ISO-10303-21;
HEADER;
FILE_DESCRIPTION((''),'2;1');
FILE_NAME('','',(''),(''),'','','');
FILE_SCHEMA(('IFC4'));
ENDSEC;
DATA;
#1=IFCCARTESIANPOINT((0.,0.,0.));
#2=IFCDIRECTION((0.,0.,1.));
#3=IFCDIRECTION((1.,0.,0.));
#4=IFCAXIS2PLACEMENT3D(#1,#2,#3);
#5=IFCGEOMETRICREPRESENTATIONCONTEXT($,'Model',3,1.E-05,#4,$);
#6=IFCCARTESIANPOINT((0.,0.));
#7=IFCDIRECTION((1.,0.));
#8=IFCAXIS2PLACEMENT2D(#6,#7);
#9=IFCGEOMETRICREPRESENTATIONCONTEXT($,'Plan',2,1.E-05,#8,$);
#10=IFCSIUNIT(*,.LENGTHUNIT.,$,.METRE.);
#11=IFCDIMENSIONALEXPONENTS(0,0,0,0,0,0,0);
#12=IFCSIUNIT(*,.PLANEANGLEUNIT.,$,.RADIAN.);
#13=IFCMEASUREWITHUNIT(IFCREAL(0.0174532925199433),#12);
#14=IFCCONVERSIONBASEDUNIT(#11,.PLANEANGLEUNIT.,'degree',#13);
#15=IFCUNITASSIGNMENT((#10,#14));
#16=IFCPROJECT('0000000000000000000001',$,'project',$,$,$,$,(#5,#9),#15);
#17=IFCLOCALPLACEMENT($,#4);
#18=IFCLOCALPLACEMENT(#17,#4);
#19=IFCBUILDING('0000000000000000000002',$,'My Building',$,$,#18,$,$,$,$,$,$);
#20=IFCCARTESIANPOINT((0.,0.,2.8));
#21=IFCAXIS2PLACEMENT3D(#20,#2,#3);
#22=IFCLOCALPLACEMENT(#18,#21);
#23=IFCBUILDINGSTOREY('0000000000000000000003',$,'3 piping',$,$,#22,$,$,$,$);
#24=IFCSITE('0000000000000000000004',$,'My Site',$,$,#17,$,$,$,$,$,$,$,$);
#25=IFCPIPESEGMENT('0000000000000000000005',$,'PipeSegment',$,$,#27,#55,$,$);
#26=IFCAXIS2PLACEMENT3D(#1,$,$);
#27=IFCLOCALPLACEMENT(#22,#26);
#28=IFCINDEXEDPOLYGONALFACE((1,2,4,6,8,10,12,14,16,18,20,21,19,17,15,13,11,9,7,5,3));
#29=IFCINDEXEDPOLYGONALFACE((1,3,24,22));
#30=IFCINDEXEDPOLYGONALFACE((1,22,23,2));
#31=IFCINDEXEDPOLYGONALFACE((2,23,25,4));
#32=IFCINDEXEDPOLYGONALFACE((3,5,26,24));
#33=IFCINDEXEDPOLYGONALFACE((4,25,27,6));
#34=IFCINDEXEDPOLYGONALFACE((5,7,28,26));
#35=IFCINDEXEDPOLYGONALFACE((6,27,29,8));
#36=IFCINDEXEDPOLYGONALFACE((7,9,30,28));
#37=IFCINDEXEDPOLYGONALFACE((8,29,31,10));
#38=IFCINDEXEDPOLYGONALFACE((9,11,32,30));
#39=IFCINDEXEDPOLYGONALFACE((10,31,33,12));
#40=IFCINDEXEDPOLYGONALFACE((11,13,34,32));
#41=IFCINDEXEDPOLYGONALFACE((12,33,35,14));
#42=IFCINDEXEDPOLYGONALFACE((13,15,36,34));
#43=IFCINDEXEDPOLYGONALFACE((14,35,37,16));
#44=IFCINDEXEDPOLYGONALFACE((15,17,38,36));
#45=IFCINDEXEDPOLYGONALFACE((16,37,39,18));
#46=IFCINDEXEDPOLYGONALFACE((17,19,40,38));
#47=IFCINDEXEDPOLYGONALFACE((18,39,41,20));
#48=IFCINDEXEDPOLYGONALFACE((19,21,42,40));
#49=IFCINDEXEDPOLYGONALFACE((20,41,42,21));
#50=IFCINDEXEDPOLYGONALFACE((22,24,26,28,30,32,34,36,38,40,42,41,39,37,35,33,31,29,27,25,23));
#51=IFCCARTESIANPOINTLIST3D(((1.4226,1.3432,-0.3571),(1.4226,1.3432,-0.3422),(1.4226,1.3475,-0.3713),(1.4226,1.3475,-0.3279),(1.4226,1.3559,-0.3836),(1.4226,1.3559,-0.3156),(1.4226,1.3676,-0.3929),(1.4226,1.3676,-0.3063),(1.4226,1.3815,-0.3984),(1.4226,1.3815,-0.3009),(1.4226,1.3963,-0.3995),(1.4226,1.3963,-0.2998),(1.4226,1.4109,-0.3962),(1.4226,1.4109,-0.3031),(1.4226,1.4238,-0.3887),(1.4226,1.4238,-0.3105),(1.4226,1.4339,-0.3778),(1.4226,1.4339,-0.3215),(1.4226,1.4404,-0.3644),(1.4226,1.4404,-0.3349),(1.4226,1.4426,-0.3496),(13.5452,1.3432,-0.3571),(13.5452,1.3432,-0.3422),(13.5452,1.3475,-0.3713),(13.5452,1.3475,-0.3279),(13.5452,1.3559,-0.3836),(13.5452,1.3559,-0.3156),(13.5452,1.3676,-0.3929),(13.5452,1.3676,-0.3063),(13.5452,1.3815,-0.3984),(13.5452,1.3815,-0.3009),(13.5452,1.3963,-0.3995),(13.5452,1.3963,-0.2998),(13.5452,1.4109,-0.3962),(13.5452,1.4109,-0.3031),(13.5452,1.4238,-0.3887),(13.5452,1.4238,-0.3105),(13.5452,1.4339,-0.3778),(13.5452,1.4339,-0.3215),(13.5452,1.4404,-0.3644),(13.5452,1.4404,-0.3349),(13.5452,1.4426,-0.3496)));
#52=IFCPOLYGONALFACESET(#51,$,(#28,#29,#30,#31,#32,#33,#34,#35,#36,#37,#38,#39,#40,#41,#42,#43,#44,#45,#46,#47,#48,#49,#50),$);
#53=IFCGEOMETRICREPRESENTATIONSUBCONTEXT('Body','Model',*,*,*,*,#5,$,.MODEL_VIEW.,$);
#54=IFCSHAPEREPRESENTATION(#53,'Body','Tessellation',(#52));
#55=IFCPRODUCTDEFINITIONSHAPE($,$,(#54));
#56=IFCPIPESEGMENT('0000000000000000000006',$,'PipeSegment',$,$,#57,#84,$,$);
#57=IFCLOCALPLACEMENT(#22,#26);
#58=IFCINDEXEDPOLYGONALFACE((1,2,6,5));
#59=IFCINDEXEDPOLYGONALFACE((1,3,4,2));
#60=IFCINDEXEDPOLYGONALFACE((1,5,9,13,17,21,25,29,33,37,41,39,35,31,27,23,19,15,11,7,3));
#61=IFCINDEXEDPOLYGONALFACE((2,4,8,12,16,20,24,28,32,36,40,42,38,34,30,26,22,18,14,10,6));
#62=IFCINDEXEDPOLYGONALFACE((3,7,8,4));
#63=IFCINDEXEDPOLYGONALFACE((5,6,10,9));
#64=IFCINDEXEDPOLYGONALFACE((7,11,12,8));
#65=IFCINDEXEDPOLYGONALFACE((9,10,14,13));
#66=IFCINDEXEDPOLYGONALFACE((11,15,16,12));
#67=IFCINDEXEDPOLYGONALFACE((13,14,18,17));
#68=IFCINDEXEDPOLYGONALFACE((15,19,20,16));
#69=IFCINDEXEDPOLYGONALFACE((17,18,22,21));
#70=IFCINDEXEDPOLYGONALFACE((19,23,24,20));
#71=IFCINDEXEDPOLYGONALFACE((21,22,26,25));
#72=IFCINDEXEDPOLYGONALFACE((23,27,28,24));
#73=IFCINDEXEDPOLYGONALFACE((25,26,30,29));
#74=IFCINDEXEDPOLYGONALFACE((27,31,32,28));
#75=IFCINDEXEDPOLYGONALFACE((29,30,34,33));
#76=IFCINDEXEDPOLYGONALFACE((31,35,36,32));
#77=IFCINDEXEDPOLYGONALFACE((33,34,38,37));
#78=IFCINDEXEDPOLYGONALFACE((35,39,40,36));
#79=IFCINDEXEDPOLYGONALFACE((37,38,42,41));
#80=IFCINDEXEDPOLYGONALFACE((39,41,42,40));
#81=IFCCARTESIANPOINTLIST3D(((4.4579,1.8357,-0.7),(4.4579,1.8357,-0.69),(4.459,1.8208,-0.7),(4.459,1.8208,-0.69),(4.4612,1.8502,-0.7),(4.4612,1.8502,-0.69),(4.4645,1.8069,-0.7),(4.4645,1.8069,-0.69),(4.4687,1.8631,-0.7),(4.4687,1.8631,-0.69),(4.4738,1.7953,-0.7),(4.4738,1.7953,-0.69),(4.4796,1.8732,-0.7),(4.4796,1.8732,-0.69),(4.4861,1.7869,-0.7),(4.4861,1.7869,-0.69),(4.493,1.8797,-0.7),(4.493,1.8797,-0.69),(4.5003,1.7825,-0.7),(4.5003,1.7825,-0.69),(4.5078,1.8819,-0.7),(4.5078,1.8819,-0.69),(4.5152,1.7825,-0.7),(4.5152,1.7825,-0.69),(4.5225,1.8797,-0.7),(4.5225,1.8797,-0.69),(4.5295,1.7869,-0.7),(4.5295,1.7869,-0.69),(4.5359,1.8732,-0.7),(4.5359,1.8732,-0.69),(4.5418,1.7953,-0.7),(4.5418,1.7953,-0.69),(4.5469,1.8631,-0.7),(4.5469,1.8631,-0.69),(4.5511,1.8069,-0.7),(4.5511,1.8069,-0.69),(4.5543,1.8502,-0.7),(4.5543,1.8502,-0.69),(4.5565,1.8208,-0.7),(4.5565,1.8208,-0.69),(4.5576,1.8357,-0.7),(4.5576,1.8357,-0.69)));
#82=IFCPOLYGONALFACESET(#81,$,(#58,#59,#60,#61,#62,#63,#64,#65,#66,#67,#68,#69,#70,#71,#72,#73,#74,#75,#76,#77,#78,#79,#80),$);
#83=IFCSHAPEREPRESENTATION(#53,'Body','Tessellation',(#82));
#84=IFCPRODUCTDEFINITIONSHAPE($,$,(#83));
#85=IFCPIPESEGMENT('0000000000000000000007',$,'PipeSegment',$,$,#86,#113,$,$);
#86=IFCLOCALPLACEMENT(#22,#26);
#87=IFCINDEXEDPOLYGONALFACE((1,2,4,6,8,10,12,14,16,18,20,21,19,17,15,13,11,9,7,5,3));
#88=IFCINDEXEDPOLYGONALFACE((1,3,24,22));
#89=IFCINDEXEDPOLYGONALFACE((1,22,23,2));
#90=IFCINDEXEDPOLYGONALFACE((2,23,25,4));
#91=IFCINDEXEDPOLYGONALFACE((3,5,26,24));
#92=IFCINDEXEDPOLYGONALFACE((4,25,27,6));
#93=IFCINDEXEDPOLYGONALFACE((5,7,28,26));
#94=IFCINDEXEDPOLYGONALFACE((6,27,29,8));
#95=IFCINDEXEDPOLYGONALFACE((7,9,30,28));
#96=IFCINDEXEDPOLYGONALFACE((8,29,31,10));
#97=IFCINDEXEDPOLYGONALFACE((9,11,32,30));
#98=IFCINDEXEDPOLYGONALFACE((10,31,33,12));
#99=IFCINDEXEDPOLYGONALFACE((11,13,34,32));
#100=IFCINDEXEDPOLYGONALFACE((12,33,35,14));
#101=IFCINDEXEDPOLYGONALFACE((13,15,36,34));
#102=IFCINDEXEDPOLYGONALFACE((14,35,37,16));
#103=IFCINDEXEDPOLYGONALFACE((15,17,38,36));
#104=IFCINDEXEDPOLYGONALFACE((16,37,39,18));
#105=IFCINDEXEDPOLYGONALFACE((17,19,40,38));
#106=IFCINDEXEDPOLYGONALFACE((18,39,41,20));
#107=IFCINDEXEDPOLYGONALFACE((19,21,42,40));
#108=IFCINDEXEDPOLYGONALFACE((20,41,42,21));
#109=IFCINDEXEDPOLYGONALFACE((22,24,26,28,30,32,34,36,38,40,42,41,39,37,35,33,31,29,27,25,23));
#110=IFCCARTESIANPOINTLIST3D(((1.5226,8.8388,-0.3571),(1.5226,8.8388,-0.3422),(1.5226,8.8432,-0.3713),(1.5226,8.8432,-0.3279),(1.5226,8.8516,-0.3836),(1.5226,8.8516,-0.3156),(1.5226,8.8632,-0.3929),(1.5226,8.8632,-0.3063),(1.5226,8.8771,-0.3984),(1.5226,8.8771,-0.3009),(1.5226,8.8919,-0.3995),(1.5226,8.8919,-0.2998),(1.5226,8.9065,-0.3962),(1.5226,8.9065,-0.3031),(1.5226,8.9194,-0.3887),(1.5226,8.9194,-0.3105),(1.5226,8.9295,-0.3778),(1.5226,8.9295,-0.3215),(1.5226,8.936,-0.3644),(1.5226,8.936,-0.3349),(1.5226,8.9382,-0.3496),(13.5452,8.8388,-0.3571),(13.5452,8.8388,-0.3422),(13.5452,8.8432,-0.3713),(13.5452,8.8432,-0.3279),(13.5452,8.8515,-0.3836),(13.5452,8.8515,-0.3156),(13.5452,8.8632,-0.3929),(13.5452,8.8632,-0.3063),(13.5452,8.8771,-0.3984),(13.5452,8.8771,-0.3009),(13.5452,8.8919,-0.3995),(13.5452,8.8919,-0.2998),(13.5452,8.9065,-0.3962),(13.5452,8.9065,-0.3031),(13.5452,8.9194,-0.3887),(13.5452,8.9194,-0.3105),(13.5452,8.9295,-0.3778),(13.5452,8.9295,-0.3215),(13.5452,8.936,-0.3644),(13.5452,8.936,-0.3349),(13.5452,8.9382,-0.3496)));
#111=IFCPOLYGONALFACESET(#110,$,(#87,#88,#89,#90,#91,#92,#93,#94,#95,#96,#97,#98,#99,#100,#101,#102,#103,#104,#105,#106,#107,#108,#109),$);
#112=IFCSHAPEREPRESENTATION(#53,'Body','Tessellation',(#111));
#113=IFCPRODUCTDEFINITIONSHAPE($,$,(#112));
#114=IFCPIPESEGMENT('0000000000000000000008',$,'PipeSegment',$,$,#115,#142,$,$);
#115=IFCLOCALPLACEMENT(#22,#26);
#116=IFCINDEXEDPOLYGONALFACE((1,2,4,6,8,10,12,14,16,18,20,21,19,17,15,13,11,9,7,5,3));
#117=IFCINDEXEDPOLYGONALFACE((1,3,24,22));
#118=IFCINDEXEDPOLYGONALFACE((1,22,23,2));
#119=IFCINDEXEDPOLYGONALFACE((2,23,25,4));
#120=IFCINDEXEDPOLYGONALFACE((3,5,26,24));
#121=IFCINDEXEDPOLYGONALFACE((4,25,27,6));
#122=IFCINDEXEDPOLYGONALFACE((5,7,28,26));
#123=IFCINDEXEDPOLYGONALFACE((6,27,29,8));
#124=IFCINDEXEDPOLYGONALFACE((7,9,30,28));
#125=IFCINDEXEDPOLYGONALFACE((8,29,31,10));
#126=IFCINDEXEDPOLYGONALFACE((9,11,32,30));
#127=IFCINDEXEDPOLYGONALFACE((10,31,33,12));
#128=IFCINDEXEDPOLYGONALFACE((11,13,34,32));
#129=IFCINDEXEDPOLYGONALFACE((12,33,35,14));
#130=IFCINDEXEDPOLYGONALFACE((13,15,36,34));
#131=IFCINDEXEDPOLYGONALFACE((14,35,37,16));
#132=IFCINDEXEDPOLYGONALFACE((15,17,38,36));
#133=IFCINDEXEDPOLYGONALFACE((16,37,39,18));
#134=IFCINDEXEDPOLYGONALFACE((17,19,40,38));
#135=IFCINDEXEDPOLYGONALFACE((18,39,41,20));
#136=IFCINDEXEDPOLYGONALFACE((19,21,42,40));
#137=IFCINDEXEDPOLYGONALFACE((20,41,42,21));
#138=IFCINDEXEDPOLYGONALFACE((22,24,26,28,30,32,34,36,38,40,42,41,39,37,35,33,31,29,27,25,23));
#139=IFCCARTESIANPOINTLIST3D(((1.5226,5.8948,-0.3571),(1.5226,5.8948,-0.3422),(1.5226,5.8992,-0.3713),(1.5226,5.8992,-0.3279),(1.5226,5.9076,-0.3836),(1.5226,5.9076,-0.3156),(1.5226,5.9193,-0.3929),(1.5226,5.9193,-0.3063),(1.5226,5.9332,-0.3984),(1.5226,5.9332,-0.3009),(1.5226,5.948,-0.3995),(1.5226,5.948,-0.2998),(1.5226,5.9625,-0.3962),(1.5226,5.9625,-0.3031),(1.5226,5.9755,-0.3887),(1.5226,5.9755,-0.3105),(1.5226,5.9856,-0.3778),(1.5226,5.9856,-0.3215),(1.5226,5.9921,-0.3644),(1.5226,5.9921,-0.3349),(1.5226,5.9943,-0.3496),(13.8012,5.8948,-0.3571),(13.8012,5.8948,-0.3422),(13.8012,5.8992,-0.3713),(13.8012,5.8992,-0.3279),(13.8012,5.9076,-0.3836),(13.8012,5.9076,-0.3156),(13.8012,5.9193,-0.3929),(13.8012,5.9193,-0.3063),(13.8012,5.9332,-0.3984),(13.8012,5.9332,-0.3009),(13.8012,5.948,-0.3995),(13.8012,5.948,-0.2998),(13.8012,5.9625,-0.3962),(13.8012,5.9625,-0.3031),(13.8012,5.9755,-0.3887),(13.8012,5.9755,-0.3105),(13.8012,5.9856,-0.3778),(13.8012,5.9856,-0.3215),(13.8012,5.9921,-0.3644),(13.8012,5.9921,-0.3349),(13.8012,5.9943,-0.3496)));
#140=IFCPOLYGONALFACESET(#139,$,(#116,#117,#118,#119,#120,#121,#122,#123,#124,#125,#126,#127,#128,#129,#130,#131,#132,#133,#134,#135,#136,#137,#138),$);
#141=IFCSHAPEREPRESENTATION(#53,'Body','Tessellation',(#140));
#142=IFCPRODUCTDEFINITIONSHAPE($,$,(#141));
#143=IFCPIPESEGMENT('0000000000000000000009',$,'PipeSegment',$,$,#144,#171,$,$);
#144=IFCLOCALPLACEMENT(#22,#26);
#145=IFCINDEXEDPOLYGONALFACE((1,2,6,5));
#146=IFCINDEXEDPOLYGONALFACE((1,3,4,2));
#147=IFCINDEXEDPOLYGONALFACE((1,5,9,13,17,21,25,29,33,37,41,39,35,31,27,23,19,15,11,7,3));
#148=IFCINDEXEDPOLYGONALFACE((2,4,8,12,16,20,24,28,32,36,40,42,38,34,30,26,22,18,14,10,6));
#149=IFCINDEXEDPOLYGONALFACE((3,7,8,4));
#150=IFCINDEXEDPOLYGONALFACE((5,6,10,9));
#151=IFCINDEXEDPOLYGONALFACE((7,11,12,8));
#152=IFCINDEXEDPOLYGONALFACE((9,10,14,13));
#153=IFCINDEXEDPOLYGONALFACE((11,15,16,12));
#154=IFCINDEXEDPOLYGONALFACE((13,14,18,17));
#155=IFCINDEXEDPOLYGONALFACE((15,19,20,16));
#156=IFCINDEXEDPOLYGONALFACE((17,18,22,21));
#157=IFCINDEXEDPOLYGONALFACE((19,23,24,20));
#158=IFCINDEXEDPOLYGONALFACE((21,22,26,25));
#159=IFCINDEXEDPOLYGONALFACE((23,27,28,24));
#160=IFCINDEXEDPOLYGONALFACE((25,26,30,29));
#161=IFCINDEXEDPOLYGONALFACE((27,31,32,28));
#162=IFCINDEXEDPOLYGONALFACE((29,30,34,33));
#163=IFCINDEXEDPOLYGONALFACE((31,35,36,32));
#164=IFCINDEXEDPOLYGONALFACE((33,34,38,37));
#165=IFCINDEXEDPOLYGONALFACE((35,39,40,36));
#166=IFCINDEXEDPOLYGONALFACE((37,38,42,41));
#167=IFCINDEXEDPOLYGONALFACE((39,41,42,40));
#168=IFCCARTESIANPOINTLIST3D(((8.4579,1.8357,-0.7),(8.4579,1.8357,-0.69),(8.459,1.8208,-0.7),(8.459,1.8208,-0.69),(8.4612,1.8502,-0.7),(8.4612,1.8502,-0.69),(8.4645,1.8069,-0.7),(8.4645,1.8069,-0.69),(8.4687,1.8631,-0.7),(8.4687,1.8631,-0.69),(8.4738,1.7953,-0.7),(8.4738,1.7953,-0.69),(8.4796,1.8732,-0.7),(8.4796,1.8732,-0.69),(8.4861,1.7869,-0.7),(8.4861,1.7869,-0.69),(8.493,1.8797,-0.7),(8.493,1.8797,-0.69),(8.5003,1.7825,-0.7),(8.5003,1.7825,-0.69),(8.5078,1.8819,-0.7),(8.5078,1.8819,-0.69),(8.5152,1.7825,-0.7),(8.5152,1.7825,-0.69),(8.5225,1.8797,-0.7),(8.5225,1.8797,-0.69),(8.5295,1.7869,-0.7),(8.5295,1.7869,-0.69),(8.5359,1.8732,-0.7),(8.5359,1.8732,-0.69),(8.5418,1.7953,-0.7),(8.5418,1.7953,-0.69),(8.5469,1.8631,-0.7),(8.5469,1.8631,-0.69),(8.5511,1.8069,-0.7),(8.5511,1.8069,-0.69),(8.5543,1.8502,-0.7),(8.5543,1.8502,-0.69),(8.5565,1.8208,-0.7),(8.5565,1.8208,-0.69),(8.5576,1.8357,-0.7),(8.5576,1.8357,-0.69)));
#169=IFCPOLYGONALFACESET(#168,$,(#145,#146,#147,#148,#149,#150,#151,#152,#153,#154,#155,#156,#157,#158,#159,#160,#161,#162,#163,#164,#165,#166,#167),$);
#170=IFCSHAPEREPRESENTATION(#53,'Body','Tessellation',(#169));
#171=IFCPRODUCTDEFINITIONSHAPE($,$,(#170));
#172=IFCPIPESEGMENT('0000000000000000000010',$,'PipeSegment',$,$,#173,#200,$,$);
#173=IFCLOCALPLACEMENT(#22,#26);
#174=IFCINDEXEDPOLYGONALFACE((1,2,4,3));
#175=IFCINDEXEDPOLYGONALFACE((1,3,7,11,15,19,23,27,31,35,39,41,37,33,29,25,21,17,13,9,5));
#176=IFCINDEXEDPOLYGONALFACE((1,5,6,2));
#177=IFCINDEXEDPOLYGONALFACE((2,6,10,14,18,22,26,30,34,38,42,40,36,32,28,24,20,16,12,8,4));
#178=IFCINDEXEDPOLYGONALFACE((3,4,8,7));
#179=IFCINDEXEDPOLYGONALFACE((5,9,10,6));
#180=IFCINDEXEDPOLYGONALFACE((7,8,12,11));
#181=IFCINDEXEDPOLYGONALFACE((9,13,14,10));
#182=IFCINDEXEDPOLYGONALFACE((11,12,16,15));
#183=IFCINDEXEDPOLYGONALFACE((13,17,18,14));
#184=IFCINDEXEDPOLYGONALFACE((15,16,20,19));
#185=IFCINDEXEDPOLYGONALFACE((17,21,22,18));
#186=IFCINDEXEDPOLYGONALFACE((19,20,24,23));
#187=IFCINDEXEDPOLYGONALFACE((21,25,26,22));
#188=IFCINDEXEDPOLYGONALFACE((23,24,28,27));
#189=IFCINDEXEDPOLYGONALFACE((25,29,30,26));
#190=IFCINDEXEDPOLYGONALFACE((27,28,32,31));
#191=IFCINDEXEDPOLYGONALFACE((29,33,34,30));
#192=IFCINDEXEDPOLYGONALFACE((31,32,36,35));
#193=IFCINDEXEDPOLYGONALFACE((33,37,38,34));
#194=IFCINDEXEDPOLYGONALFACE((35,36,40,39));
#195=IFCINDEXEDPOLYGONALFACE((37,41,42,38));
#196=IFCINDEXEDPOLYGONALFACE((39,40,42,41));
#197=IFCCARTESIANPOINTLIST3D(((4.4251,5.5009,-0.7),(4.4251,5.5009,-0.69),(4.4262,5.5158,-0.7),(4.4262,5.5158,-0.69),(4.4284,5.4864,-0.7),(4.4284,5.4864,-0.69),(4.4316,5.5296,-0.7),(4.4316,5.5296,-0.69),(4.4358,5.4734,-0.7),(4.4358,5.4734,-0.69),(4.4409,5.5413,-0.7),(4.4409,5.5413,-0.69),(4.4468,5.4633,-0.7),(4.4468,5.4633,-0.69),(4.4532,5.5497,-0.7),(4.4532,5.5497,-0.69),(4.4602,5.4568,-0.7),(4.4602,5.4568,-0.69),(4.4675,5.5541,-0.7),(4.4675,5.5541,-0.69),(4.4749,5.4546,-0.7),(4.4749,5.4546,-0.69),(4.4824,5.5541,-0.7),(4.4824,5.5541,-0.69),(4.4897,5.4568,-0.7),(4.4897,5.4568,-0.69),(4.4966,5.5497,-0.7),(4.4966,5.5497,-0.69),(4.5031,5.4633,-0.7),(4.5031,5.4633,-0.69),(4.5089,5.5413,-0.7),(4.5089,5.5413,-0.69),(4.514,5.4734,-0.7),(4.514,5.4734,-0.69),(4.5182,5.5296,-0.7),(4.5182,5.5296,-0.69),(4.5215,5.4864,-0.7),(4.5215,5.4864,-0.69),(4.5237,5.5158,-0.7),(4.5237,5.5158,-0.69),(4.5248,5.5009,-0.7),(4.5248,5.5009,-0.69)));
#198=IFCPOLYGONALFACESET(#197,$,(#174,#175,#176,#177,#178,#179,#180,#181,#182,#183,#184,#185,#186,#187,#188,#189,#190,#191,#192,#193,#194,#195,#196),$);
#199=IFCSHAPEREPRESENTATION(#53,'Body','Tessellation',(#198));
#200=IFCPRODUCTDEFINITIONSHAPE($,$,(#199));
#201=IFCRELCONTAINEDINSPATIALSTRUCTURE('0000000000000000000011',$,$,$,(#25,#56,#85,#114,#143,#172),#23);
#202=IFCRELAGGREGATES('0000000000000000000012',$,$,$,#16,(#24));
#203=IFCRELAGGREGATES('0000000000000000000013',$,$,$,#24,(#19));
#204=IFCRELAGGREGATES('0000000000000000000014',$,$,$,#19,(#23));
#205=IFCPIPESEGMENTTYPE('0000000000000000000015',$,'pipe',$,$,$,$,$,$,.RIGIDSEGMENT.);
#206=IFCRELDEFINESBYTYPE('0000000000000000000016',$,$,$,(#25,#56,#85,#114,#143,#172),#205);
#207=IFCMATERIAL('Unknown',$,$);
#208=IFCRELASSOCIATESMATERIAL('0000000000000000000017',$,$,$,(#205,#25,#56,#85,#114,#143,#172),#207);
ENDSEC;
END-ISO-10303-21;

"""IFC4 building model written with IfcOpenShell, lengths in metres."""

from ifc_helpers import new_model, entity, si_unit, converted_unit, frame, origin_with_axes, origin_2d_with_axis, place, context, subcontext, project, spatial, circle, extrude, material, material_profile, profile_set, profile_usage, type_object, element, save


model = new_model("IFC4")

# Units and contexts
model_context = context("Model", 3, precision=1e-05, world=origin_with_axes())
plan_context = context("Plan", 2, precision=1e-05, world=origin_2d_with_axis())
body_context = subcontext(model_context, "Body", "Model", "MODEL_VIEW")
ifc_project = project(units=[si_unit("LENGTHUNIT", "METRE"), converted_unit("PLANEANGLEUNIT", "degree", entity("IfcReal", 0.0174532925199433), si_unit("PLANEANGLEUNIT", "RADIAN"), dimensions=[0, 0, 0, 0, 0, 0, 0])], contexts=[model_context, plan_context])

# Site, building, storey
site_placement = place(None, origin_with_axes())
site = spatial("IfcSite", under=ifc_project, at=site_placement, Name="My Site")
building_placement = place(site_placement, origin_with_axes())
building = spatial("IfcBuilding", under=site, at=building_placement, Name="My Building")
storey_placement = place(building_placement, frame((0.0, 0.0, 2.8), z_axis=(0.0, 0.0, 1.0), x_axis=(1.0, 0.0, 0.0)))
storey = spatial("IfcBuildingStorey", under=building, at=storey_placement, Name="3 piping")

# Pipe segments
ifc_material = material(Name="Unknown")
ifc_material_profile_1 = material_profile(ifc_material, circle(Radius=0.05))
ifc_profile_set_1 = profile_set([ifc_material_profile_1])
ifc_profile_usage_1 = profile_usage(ifc_profile_set_1, cardinal=2)
pipe_segment_type = type_object("IfcPipeSegmentType", Name="pipe", PredefinedType="RIGIDSEGMENT", material=ifc_profile_set_1)
pipe_segment_1_placement = place(storey_placement, frame((1.4226, 1.3926, -0.3996), z_axis=(1.0, 0.0, 0.0), x_axis=(0.0, 1.0, 0.0)))
element("IfcPipeSegment", 1, at=pipe_segment_1_placement, inside=storey, type_object=pipe_segment_type, material=ifc_profile_usage_1, Name="PipeSegment", context=body_context, shape_type="SweptSolid", body=[
    extrude(circle(Radius=0.05), frame((0.0, 0.05, 0.0), z_axis=(0.0, 0.0, 1.0), x_axis=(1.0, 0.0, 0.0)), (0.0, 0.0, 1.0), 12.1226),
])
ifc_profile_usage_2 = profile_usage(ifc_profile_set_1, cardinal=2)
pipe_segment_2_placement = place(storey_placement, frame((4.4578, 1.8319, -0.69), z_axis=(0.0, 0.0, -1.0), x_axis=(0.0, 1.0, 0.0)))
element("IfcPipeSegment", 2, at=pipe_segment_2_placement, inside=storey, type_object=pipe_segment_type, material=ifc_profile_usage_2, Name="PipeSegment", context=body_context, shape_type="SweptSolid", body=[
    extrude(circle(Radius=0.05), frame((0.0, 0.05, 0.0), z_axis=(0.0, 0.0, 1.0), x_axis=(1.0, 0.0, 0.0)), (0.0, 0.0, 1.0), 0.01),
])
ifc_profile_usage_3 = profile_usage(ifc_profile_set_1, cardinal=2)
pipe_segment_3_placement = place(storey_placement, frame((1.5226, 8.8882, -0.3996), z_axis=(1.0, 0.0, 0.0), x_axis=(0.0, 1.0, 0.0)))
element("IfcPipeSegment", 3, at=pipe_segment_3_placement, inside=storey, type_object=pipe_segment_type, material=ifc_profile_usage_3, Name="PipeSegment", context=body_context, shape_type="SweptSolid", body=[
    extrude(circle(Radius=0.05), frame((0.0, 0.05, 0.0), z_axis=(0.0, 0.0, 1.0), x_axis=(1.0, 0.0, 0.0)), (0.0, 0.0, 1.0), 12.0226),
])
ifc_profile_usage_4 = profile_usage(ifc_profile_set_1, cardinal=2)
pipe_segment_4_placement = place(storey_placement, frame((1.5226, 5.9443, -0.3996), z_axis=(1.0, 0.0, 0.0), x_axis=(0.0, 1.0, 0.0)))
element("IfcPipeSegment", 4, at=pipe_segment_4_placement, inside=storey, type_object=pipe_segment_type, material=ifc_profile_usage_4, Name="PipeSegment", context=body_context, shape_type="SweptSolid", body=[
    extrude(circle(Radius=0.05), frame((0.0, 0.05, 0.0), z_axis=(0.0, 0.0, 1.0), x_axis=(1.0, 0.0, 0.0)), (0.0, 0.0, 1.0), 12.2786),
])
ifc_profile_usage_5 = profile_usage(ifc_profile_set_1, cardinal=2)
pipe_segment_5_placement = place(storey_placement, frame((8.4578, 1.8319, -0.69), z_axis=(0.0, 0.0, -1.0), x_axis=(0.0, 1.0, 0.0)))
element("IfcPipeSegment", 5, at=pipe_segment_5_placement, inside=storey, type_object=pipe_segment_type, material=ifc_profile_usage_5, Name="PipeSegment", context=body_context, shape_type="SweptSolid", body=[
    extrude(circle(Radius=0.05), frame((0.0, 0.05, 0.0), z_axis=(0.0, 0.0, 1.0), x_axis=(1.0, 0.0, 0.0)), (0.0, 0.0, 1.0), 0.01),
])
ifc_profile_usage_6 = profile_usage(ifc_profile_set_1, cardinal=2)
pipe_segment_6_placement = place(storey_placement, frame((4.5249, 5.5046, -0.69), z_axis=(0.0, 0.0, -1.0), x_axis=(0.0, -1.0, 0.0)))
element("IfcPipeSegment", 6, at=pipe_segment_6_placement, inside=storey, type_object=pipe_segment_type, material=ifc_profile_usage_6, Name="PipeSegment", context=body_context, shape_type="SweptSolid", body=[
    extrude(circle(Radius=0.05), frame((0.0, 0.05, 0.0), z_axis=(0.0, 0.0, 1.0), x_axis=(1.0, 0.0, 0.0)), (0.0, 0.0, 1.0), 0.01),
])

save(model, "model.ifc")
